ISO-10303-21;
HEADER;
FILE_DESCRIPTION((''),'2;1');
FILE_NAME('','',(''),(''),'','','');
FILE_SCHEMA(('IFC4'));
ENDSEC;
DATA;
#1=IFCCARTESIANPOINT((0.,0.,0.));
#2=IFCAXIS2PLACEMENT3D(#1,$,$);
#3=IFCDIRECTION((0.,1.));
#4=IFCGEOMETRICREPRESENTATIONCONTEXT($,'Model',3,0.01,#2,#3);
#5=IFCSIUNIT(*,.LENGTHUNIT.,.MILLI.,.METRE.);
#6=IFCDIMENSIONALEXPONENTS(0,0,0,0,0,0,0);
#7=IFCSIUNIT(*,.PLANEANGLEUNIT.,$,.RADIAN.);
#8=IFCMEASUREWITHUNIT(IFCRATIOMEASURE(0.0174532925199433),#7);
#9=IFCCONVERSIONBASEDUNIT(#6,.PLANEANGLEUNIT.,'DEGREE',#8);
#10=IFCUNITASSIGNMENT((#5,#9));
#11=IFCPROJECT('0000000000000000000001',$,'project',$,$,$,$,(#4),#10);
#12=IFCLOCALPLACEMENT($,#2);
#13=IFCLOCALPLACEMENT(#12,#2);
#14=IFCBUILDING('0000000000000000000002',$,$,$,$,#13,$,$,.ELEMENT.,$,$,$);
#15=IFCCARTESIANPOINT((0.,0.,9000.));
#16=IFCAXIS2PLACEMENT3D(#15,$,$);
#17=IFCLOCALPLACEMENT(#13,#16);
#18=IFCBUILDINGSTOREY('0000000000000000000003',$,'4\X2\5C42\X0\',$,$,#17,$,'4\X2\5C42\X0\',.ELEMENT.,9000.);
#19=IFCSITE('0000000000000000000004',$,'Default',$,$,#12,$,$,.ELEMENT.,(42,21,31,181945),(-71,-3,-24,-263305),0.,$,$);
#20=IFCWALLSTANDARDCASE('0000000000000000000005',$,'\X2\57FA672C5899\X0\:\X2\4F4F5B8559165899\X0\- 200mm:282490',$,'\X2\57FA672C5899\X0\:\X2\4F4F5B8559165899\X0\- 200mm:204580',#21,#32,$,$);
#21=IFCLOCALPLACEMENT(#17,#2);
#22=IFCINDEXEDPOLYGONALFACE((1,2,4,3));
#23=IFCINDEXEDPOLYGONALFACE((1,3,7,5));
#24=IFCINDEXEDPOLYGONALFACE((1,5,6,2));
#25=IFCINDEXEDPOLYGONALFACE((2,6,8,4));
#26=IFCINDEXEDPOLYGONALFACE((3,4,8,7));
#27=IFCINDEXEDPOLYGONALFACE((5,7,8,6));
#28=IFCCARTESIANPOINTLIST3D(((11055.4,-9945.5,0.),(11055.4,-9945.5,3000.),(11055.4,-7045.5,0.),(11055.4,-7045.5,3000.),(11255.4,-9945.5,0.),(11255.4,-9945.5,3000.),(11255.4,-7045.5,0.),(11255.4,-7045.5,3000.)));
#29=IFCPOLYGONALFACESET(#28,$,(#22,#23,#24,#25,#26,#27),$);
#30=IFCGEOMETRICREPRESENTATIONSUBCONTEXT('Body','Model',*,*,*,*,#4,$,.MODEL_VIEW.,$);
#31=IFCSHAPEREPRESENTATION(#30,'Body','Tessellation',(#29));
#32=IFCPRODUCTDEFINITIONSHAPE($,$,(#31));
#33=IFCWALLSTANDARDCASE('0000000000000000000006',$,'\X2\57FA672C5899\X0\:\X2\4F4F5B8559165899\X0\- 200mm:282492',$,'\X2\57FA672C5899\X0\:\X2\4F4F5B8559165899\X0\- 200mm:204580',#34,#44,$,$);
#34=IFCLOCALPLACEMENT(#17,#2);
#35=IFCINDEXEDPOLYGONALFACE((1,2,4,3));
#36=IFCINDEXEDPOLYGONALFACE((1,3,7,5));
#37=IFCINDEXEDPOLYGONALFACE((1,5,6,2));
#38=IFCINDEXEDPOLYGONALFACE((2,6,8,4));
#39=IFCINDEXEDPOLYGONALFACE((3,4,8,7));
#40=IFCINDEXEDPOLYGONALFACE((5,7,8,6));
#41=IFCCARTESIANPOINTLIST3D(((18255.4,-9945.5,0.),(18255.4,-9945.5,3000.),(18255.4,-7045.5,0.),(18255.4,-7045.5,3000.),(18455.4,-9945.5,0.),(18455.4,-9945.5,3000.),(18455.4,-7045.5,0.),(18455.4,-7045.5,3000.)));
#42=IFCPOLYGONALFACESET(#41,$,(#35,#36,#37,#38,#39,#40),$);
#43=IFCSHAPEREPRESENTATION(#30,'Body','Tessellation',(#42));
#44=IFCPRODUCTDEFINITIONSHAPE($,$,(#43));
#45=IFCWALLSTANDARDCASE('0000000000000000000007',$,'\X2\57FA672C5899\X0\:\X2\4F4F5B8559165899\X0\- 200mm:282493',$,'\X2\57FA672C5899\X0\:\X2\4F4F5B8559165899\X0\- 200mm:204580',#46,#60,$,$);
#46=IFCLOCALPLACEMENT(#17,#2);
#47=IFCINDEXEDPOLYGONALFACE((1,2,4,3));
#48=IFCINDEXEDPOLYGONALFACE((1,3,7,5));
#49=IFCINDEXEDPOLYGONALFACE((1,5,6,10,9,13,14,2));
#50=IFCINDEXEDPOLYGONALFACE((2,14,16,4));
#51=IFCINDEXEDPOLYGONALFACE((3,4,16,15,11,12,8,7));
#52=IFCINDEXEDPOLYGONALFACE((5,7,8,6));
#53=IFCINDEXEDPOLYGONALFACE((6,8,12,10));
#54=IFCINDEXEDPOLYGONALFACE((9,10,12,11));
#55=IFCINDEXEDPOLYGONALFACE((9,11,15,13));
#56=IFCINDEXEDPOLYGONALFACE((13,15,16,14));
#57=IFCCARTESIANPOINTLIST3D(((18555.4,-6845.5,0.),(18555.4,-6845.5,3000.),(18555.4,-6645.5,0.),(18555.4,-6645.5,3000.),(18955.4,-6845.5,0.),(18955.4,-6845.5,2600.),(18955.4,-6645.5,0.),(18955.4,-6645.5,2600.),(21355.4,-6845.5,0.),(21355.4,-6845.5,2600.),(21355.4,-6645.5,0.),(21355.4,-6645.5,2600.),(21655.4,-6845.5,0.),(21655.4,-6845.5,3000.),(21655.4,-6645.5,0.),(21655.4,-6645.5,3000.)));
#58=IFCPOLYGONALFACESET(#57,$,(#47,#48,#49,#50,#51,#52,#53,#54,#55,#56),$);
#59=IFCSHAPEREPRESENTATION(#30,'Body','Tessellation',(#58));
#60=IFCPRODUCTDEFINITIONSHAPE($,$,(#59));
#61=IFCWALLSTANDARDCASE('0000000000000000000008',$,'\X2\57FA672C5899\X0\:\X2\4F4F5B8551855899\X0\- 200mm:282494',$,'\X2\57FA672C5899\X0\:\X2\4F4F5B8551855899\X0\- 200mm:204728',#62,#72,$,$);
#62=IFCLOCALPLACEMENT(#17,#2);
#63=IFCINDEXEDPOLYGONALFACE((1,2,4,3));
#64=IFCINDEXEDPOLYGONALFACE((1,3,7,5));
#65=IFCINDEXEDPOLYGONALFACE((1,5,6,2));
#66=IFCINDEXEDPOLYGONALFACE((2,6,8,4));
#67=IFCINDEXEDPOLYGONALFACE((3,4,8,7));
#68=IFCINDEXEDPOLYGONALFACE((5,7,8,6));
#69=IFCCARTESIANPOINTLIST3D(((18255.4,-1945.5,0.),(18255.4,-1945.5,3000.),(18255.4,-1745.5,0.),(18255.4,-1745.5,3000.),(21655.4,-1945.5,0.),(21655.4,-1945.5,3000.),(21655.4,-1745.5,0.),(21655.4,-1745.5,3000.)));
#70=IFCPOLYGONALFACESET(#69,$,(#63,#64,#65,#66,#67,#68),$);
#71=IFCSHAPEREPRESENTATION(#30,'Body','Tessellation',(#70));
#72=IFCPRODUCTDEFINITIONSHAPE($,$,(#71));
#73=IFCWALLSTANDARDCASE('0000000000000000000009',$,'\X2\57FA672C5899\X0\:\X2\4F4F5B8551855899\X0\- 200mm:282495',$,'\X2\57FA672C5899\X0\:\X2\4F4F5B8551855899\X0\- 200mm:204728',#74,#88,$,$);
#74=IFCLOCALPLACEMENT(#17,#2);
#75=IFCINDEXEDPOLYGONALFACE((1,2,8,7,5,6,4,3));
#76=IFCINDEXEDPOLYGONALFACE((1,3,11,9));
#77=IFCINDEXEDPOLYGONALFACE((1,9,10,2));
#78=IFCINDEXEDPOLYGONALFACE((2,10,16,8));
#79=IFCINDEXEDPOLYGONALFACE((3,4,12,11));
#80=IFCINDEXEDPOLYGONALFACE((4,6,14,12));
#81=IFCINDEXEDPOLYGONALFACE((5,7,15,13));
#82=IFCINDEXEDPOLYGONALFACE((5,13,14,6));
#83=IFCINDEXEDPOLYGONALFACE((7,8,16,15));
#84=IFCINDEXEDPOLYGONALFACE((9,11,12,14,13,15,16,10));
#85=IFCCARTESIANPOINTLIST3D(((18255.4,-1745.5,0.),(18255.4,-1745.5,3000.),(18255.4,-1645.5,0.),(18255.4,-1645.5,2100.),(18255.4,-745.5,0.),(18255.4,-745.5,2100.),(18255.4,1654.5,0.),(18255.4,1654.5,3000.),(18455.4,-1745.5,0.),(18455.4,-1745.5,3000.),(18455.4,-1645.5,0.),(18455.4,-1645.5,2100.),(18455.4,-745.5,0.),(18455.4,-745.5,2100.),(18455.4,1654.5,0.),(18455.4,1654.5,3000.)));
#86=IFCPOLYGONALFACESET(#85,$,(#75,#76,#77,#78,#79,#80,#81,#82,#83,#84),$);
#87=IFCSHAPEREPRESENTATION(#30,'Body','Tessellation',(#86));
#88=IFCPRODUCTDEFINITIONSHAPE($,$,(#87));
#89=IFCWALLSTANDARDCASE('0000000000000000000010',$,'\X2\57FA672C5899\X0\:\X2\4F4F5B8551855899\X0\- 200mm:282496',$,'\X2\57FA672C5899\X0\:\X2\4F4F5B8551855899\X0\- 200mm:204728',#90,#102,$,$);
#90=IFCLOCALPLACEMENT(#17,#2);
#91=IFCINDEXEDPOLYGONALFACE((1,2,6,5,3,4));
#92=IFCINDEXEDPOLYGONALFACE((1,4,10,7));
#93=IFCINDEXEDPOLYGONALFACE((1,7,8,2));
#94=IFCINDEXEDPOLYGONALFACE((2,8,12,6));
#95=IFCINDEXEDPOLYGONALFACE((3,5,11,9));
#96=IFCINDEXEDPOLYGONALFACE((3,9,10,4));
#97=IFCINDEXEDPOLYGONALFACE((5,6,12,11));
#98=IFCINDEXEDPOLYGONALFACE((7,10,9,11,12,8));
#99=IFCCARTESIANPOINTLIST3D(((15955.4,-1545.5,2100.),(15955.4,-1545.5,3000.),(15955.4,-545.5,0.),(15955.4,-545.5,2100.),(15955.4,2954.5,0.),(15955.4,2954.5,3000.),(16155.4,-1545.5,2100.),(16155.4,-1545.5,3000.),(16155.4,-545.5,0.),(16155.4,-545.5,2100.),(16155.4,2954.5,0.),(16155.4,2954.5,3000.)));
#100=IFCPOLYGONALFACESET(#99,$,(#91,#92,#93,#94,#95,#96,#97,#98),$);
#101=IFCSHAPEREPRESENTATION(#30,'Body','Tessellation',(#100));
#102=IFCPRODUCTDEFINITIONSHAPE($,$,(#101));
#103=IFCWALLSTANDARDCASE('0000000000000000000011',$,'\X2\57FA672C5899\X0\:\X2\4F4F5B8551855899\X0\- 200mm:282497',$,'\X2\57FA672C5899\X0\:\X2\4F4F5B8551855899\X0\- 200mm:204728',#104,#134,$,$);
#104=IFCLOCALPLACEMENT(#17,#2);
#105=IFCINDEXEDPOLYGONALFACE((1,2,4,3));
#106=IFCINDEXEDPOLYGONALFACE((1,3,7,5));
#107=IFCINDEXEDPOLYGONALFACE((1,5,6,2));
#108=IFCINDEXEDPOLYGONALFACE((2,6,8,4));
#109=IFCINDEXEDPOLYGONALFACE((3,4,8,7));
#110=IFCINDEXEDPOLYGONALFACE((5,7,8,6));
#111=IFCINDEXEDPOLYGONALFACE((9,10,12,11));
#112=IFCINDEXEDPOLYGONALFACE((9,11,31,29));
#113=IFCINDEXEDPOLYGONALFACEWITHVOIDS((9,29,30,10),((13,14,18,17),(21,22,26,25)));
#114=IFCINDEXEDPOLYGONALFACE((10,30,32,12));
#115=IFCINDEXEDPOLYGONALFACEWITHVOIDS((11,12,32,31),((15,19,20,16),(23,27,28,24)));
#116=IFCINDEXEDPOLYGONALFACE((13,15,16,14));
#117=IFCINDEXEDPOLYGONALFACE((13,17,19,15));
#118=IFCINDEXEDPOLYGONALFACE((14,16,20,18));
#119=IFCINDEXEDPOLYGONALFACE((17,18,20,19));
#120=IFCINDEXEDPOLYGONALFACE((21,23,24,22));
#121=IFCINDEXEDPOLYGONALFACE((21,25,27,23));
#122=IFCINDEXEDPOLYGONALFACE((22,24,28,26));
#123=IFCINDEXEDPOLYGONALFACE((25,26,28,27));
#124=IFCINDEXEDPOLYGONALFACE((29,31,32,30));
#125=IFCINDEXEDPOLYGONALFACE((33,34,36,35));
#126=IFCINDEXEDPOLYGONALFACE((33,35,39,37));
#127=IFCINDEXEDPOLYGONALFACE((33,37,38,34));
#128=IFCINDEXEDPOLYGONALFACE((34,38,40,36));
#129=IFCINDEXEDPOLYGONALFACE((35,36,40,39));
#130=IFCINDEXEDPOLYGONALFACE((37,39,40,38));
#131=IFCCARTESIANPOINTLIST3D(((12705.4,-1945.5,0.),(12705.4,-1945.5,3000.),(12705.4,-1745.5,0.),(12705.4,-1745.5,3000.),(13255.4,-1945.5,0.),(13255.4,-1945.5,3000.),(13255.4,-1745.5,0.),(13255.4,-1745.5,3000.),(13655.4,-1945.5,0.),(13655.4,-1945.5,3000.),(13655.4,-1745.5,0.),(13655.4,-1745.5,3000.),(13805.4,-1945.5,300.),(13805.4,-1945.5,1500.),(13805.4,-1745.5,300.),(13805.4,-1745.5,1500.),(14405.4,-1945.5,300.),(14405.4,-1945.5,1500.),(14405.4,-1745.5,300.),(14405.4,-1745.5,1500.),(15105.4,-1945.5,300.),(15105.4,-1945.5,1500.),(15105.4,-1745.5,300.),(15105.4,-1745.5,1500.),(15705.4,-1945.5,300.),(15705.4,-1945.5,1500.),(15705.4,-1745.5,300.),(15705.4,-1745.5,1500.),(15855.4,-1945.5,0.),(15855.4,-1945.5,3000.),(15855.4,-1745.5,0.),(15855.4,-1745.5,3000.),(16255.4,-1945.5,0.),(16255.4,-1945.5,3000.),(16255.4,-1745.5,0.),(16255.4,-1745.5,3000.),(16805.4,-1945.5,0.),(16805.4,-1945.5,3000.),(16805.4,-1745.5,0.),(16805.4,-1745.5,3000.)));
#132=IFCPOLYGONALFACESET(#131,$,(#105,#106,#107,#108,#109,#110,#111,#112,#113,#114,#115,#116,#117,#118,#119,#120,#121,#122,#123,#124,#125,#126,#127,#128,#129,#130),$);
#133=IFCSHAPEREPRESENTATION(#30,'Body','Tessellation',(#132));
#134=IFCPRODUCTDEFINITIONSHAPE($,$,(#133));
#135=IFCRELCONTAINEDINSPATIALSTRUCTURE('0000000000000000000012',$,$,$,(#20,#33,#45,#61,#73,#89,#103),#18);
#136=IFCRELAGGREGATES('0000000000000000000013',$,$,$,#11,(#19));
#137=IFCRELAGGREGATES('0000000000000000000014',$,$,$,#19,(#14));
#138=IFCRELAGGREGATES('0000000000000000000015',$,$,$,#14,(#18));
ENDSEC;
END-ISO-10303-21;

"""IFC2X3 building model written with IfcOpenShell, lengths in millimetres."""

from ifc_helpers import new_model, entity, si_unit, converted_unit, direction, frame, frame_2d, origin, place, context, subcontext, project, spatial, polyline, rectangle, extrude, clip, bounded_halfspace, element, save


model = new_model("IFC2X3")

# Units and contexts
model_context = context("Model", 3, precision=0.01, world=origin(), true_north=direction((0.0, 1.0)))
body_context = subcontext(model_context, "Body", "Model", "MODEL_VIEW")
ifc_project = project(units=[si_unit("LENGTHUNIT", "METRE", prefix="MILLI"), converted_unit("PLANEANGLEUNIT", "DEGREE", entity("IfcRatioMeasure", 0.0174532925199433), si_unit("PLANEANGLEUNIT", "RADIAN"), dimensions=[0, 0, 0, 0, 0, 0, 0])], contexts=[model_context])

# Site, building, storey
site_placement = place(None, origin())
site = spatial("IfcSite", under=ifc_project, at=site_placement, Name="Default", CompositionType="ELEMENT", RefLatitude=(42, 21, 31, 181945), RefLongitude=(-71, -3, -24, -263305), RefElevation=0.0)
building_placement = place(site_placement, origin())
building = spatial("IfcBuilding", under=site, at=building_placement, CompositionType="ELEMENT")
storey_placement = place(building_placement, frame((0.0, 0.0, 9000.0)))
storey = spatial("IfcBuildingStorey", under=building, at=storey_placement, Name="4层", LongName="4层", CompositionType="ELEMENT", Elevation=9000.0)

# Walls
wall_1_placement = place(storey_placement, frame((11155.4, -7045.5, 0.0), z_axis=(0.0, 0.0, 1.0), x_axis=(0.0, -1.0, 0.0)))
element("IfcWallStandardCase", 1, at=wall_1_placement, inside=storey, Name="基本墙:住宅外墙- 200mm:282490", ObjectType="基本墙:住宅外墙- 200mm:204580", context=body_context, shape_type="Clipping", body=[
    clip(clip(extrude(rectangle(XDim=2900.0, YDim=200.0, at=frame_2d((1450.0, 0.0), x_axis=(-1.0, 0.0))), origin(), (0.0, 0.0, 1.0), 3000.0), bounded_halfspace(frame((0.0, -100.0, 0.0), z_axis=(1.0, 0.0, 0.0), x_axis=(0.0, 0.0, -1.0)), True, frame((0.0, -100.0, 0.0), z_axis=(1.0, 0.0, 0.0), x_axis=(0.0, 0.0, -1.0)), polyline([(0.0, 0.0), (0.0, 200.0), (-3000.0, 200.0), (-3000.0, 0.0), (0.0, 0.0)]))), bounded_halfspace(frame((2900.0, -100.0, 3000.0), z_axis=(-1.0, 0.0, 0.0), x_axis=(0.0, 0.0, -1.0)), True, frame((2900.0, -100.0, 3000.0), z_axis=(-1.0, 0.0, 0.0), x_axis=(0.0, 0.0, -1.0)), polyline([(0.0, 0.0), (0.0, -200.0), (3000.0, -200.0), (3000.0, 0.0), (0.0, 0.0)]))),
])
wall_2_placement = place(storey_placement, frame((18355.4, -9945.5, 0.0), z_axis=(0.0, 0.0, 1.0), x_axis=(0.0, 1.0, 0.0)))
element("IfcWallStandardCase", 2, at=wall_2_placement, inside=storey, Name="基本墙:住宅外墙- 200mm:282492", ObjectType="基本墙:住宅外墙- 200mm:204580", context=body_context, shape_type="Clipping", body=[
    clip(clip(extrude(rectangle(XDim=2900.0, YDim=200.0, at=frame_2d((1450.0, 0.0), x_axis=(-1.0, 0.0))), origin(), (0.0, 0.0, 1.0), 3000.0), bounded_halfspace(frame((0.0, -100.0, 0.0), z_axis=(-1.0, 0.0, 0.0), x_axis=(0.0, 0.0, -1.0)), False, frame((0.0, -100.0, 0.0), z_axis=(-1.0, 0.0, 0.0), x_axis=(0.0, 0.0, -1.0)), polyline([(0.0, 0.0), (-3000.0, 0.0), (-3000.0, -200.0), (0.0, -200.0), (0.0, 0.0)]))), bounded_halfspace(frame((2900.0, -100.0, 3000.0), z_axis=(1.0, 0.0, 0.0), x_axis=(0.0, 0.0, -1.0)), False, frame((2900.0, -100.0, 3000.0), z_axis=(1.0, 0.0, 0.0), x_axis=(0.0, 0.0, -1.0)), polyline([(0.0, 0.0), (3000.0, 0.0), (3000.0, 200.0), (0.0, 200.0), (0.0, 0.0)]))),
])

# Wall, opening
wall_3_placement = place(storey_placement, frame((18555.4, -6745.5, 0.0)))
wall_3 = element("IfcWallStandardCase", 3, at=wall_3_placement, inside=storey, Name="基本墙:住宅外墙- 200mm:282493", ObjectType="基本墙:住宅外墙- 200mm:204580", context=body_context, shape_type="Clipping", body=[
    clip(clip(extrude(rectangle(XDim=3100.0, YDim=200.0, at=frame_2d((1550.0, 0.0), x_axis=(-1.0, 0.0))), origin(), (0.0, 0.0, 1.0), 3000.0), bounded_halfspace(frame((0.0, -100.0, 0.0), z_axis=(-1.0, 0.0, 0.0), x_axis=(0.0, 0.0, -1.0)), False, frame((0.0, -100.0, 0.0), z_axis=(-1.0, 0.0, 0.0), x_axis=(0.0, 0.0, -1.0)), polyline([(0.0, 0.0), (-3000.0, 0.0), (-3000.0, -200.0), (0.0, -200.0), (0.0, 0.0)]))), bounded_halfspace(frame((3100.0, -100.0, 3000.0), z_axis=(1.0, 0.0, 0.0), x_axis=(0.0, 0.0, -1.0)), False, frame((3100.0, -100.0, 3000.0), z_axis=(1.0, 0.0, 0.0), x_axis=(0.0, 0.0, -1.0)), polyline([(0.0, 0.0), (3000.0, 0.0), (3000.0, 200.0), (0.0, 200.0), (0.0, 0.0)]))),
])
opening_1_placement = place(wall_3_placement, frame((2800.0, 100.0, 0.0)))
element("IfcOpeningElement", 4, at=opening_1_placement, cuts=wall_3, ObjectType="Opening", context=body_context, shape_type="SweptSolid", body=[
    extrude(rectangle(XDim=2600.0, YDim=2400.0, at=frame_2d((1300.0, 1200.0), x_axis=(1.0, 0.0))), frame((0.0, 0.0, 0.0), z_axis=(0.0, -1.0, 0.0), x_axis=(0.0, 0.0, 1.0)), (0.0, 0.0, 1.0), 200.0),
])

# Wall
wall_4_placement = place(storey_placement, frame((21655.4, -1845.5, 0.0), z_axis=(0.0, 0.0, 1.0), x_axis=(-1.0, 0.0, 0.0)))
element("IfcWallStandardCase", 5, at=wall_4_placement, inside=storey, Name="基本墙:住宅内墙- 200mm:282494", ObjectType="基本墙:住宅内墙- 200mm:204728", context=body_context, shape_type="Clipping", body=[
    clip(extrude(rectangle(XDim=3400.0, YDim=200.0, at=frame_2d((1700.0, 0.0), x_axis=(-1.0, 0.0))), origin(), (0.0, 0.0, 1.0), 3000.0), bounded_halfspace(frame((0.0, -100.0, 0.0), z_axis=(-1.0, 0.0, 0.0), x_axis=(0.0, 0.0, -1.0)), False, frame((0.0, -100.0, 0.0), z_axis=(-1.0, 0.0, 0.0), x_axis=(0.0, 0.0, -1.0)), polyline([(0.0, 0.0), (-3000.0, 0.0), (-3000.0, -200.0), (0.0, -200.0), (0.0, 0.0)]))),
])

# Walls, openings
wall_5_placement = place(storey_placement, frame((18355.4, -1745.5, 0.0), z_axis=(0.0, 0.0, 1.0), x_axis=(0.0, 1.0, 0.0)))
wall_5 = element("IfcWallStandardCase", 6, at=wall_5_placement, inside=storey, Name="基本墙:住宅内墙- 200mm:282495", ObjectType="基本墙:住宅内墙- 200mm:204728", context=body_context, shape_type="SweptSolid", body=[
    extrude(rectangle(XDim=3400.0, YDim=200.0, at=frame_2d((1700.0, 0.0), x_axis=(-1.0, 0.0))), origin(), (0.0, 0.0, 1.0), 3000.0),
])
opening_2_placement = place(wall_5_placement, frame((1000.0, 100.0, 0.0)))
element("IfcOpeningElement", 7, at=opening_2_placement, cuts=wall_5, ObjectType="Opening", context=body_context, shape_type="SweptSolid", body=[
    extrude(rectangle(XDim=2100.0, YDim=900.0, at=frame_2d((1050.0, 450.0), x_axis=(1.0, 0.0))), frame((0.0, 0.0, 0.0), z_axis=(0.0, -1.0, 0.0), x_axis=(0.0, 0.0, 1.0)), (0.0, 0.0, 1.0), 200.0),
])
wall_6_placement = place(storey_placement, frame((16055.4, 2954.5, 0.0), z_axis=(0.0, 0.0, 1.0), x_axis=(0.0, -1.0, 0.0)))
wall_6 = element("IfcWallStandardCase", 8, at=wall_6_placement, inside=storey, Name="基本墙:住宅内墙- 200mm:282496", ObjectType="基本墙:住宅内墙- 200mm:204728", context=body_context, shape_type="Clipping", body=[
    clip(clip(extrude(rectangle(XDim=4500.0, YDim=200.0, at=frame_2d((2250.0, 0.0), x_axis=(-1.0, 0.0))), origin(), (0.0, 0.0, 1.0), 3000.0), bounded_halfspace(frame((4500.0, -100.0, 3000.0), z_axis=(1.0, 0.0, 0.0), x_axis=(0.0, 0.0, -1.0)), False, frame((4500.0, -100.0, 3000.0), z_axis=(1.0, 0.0, 0.0), x_axis=(0.0, 0.0, -1.0)), polyline([(0.0, 0.0), (900.0, 0.0), (900.0, 200.0), (0.0, 200.0), (0.0, 0.0)]))), bounded_halfspace(frame((0.0, -100.0, 0.0), z_axis=(-1.0, 0.0, 0.0), x_axis=(0.0, 0.0, -1.0)), False, frame((0.0, -100.0, 0.0), z_axis=(-1.0, 0.0, 0.0), x_axis=(0.0, 0.0, -1.0)), polyline([(0.0, 0.0), (-3000.0, 0.0), (-3000.0, -200.0), (0.0, -200.0), (0.0, 0.0)]))),
])
opening_3_placement = place(wall_6_placement, frame((4500.0, 100.0, 0.0)))
element("IfcOpeningElement", 9, at=opening_3_placement, cuts=wall_6, ObjectType="Opening", context=body_context, shape_type="SweptSolid", body=[
    extrude(rectangle(XDim=2100.0, YDim=1000.0, at=frame_2d((1050.0, 500.0), x_axis=(1.0, 0.0))), frame((0.0, 0.0, 0.0), z_axis=(0.0, -1.0, 0.0), x_axis=(0.0, 0.0, 1.0)), (0.0, 0.0, 1.0), 200.0),
])

# Wall, openings
wall_7_placement = place(storey_placement, frame((16805.4, -1845.5, 0.0), z_axis=(0.0, 0.0, 1.0), x_axis=(-1.0, 0.0, 0.0)))
wall_7 = element("IfcWallStandardCase", 10, at=wall_7_placement, inside=storey, Name="基本墙:住宅内墙- 200mm:282497", ObjectType="基本墙:住宅内墙- 200mm:204728", context=body_context, shape_type="SweptSolid", body=[
    extrude(rectangle(XDim=4100.0, YDim=200.0, at=frame_2d((2050.0, 0.0), x_axis=(-1.0, 0.0))), origin(), (0.0, 0.0, 1.0), 3000.0),
])
opening_4_placement = place(wall_7_placement, frame((2400.0, -100.0, 300.0)))
element("IfcOpeningElement", 11, at=opening_4_placement, cuts=wall_7, ObjectType="Opening", context=body_context, shape_type="SweptSolid", body=[
    extrude(rectangle(XDim=1200.0, YDim=600.0, at=frame_2d((600.0, 300.0), x_axis=(-1.0, 0.0))), frame((0.0, 0.0, 0.0), z_axis=(0.0, 1.0, 0.0), x_axis=(0.0, 0.0, 1.0)), (0.0, 0.0, 1.0), 200.0),
])
opening_5_placement = place(wall_7_placement, frame((1100.0, -100.0, 300.0)))
element("IfcOpeningElement", 12, at=opening_5_placement, cuts=wall_7, ObjectType="Opening", context=body_context, shape_type="SweptSolid", body=[
    extrude(rectangle(XDim=1200.0, YDim=600.0, at=frame_2d((600.0, 300.0), x_axis=(-1.0, 0.0))), frame((0.0, 0.0, 0.0), z_axis=(0.0, 1.0, 0.0), x_axis=(0.0, 0.0, 1.0)), (0.0, 0.0, 1.0), 200.0),
])
opening_6_placement = place(storey_placement, frame((16805.4, -1845.5, 0.0), z_axis=(0.0, 0.0, 1.0), x_axis=(-1.0, 0.0, 0.0)))
element("IfcOpeningElement", 13, at=opening_6_placement, cuts=wall_7, ObjectType="Opening", context=body_context, shape_type="SweptSolid", body=[
    extrude(rectangle(XDim=3000.0, YDim=200.0, at=frame_2d((0.0, 0.0), x_axis=(1.0, 0.0))), frame((3550.0, 0.0, 1500.0), z_axis=(-1.0, 0.0, 0.0), x_axis=(0.0, 0.0, 1.0)), (0.0, 0.0, 1.0), 400.0),
])
opening_7_placement = place(storey_placement, frame((16805.4, -1845.5, 0.0), z_axis=(0.0, 0.0, 1.0), x_axis=(-1.0, 0.0, 0.0)))
element("IfcOpeningElement", 14, at=opening_7_placement, cuts=wall_7, ObjectType="Opening", context=body_context, shape_type="SweptSolid", body=[
    extrude(rectangle(XDim=3000.0, YDim=200.0, at=frame_2d((0.0, 0.0), x_axis=(1.0, 0.0))), frame((950.0, 0.0, 1500.0), z_axis=(-1.0, 0.0, 0.0), x_axis=(0.0, 0.0, 1.0)), (0.0, 0.0, 1.0), 400.0),
])

save(model, "model.ifc")
